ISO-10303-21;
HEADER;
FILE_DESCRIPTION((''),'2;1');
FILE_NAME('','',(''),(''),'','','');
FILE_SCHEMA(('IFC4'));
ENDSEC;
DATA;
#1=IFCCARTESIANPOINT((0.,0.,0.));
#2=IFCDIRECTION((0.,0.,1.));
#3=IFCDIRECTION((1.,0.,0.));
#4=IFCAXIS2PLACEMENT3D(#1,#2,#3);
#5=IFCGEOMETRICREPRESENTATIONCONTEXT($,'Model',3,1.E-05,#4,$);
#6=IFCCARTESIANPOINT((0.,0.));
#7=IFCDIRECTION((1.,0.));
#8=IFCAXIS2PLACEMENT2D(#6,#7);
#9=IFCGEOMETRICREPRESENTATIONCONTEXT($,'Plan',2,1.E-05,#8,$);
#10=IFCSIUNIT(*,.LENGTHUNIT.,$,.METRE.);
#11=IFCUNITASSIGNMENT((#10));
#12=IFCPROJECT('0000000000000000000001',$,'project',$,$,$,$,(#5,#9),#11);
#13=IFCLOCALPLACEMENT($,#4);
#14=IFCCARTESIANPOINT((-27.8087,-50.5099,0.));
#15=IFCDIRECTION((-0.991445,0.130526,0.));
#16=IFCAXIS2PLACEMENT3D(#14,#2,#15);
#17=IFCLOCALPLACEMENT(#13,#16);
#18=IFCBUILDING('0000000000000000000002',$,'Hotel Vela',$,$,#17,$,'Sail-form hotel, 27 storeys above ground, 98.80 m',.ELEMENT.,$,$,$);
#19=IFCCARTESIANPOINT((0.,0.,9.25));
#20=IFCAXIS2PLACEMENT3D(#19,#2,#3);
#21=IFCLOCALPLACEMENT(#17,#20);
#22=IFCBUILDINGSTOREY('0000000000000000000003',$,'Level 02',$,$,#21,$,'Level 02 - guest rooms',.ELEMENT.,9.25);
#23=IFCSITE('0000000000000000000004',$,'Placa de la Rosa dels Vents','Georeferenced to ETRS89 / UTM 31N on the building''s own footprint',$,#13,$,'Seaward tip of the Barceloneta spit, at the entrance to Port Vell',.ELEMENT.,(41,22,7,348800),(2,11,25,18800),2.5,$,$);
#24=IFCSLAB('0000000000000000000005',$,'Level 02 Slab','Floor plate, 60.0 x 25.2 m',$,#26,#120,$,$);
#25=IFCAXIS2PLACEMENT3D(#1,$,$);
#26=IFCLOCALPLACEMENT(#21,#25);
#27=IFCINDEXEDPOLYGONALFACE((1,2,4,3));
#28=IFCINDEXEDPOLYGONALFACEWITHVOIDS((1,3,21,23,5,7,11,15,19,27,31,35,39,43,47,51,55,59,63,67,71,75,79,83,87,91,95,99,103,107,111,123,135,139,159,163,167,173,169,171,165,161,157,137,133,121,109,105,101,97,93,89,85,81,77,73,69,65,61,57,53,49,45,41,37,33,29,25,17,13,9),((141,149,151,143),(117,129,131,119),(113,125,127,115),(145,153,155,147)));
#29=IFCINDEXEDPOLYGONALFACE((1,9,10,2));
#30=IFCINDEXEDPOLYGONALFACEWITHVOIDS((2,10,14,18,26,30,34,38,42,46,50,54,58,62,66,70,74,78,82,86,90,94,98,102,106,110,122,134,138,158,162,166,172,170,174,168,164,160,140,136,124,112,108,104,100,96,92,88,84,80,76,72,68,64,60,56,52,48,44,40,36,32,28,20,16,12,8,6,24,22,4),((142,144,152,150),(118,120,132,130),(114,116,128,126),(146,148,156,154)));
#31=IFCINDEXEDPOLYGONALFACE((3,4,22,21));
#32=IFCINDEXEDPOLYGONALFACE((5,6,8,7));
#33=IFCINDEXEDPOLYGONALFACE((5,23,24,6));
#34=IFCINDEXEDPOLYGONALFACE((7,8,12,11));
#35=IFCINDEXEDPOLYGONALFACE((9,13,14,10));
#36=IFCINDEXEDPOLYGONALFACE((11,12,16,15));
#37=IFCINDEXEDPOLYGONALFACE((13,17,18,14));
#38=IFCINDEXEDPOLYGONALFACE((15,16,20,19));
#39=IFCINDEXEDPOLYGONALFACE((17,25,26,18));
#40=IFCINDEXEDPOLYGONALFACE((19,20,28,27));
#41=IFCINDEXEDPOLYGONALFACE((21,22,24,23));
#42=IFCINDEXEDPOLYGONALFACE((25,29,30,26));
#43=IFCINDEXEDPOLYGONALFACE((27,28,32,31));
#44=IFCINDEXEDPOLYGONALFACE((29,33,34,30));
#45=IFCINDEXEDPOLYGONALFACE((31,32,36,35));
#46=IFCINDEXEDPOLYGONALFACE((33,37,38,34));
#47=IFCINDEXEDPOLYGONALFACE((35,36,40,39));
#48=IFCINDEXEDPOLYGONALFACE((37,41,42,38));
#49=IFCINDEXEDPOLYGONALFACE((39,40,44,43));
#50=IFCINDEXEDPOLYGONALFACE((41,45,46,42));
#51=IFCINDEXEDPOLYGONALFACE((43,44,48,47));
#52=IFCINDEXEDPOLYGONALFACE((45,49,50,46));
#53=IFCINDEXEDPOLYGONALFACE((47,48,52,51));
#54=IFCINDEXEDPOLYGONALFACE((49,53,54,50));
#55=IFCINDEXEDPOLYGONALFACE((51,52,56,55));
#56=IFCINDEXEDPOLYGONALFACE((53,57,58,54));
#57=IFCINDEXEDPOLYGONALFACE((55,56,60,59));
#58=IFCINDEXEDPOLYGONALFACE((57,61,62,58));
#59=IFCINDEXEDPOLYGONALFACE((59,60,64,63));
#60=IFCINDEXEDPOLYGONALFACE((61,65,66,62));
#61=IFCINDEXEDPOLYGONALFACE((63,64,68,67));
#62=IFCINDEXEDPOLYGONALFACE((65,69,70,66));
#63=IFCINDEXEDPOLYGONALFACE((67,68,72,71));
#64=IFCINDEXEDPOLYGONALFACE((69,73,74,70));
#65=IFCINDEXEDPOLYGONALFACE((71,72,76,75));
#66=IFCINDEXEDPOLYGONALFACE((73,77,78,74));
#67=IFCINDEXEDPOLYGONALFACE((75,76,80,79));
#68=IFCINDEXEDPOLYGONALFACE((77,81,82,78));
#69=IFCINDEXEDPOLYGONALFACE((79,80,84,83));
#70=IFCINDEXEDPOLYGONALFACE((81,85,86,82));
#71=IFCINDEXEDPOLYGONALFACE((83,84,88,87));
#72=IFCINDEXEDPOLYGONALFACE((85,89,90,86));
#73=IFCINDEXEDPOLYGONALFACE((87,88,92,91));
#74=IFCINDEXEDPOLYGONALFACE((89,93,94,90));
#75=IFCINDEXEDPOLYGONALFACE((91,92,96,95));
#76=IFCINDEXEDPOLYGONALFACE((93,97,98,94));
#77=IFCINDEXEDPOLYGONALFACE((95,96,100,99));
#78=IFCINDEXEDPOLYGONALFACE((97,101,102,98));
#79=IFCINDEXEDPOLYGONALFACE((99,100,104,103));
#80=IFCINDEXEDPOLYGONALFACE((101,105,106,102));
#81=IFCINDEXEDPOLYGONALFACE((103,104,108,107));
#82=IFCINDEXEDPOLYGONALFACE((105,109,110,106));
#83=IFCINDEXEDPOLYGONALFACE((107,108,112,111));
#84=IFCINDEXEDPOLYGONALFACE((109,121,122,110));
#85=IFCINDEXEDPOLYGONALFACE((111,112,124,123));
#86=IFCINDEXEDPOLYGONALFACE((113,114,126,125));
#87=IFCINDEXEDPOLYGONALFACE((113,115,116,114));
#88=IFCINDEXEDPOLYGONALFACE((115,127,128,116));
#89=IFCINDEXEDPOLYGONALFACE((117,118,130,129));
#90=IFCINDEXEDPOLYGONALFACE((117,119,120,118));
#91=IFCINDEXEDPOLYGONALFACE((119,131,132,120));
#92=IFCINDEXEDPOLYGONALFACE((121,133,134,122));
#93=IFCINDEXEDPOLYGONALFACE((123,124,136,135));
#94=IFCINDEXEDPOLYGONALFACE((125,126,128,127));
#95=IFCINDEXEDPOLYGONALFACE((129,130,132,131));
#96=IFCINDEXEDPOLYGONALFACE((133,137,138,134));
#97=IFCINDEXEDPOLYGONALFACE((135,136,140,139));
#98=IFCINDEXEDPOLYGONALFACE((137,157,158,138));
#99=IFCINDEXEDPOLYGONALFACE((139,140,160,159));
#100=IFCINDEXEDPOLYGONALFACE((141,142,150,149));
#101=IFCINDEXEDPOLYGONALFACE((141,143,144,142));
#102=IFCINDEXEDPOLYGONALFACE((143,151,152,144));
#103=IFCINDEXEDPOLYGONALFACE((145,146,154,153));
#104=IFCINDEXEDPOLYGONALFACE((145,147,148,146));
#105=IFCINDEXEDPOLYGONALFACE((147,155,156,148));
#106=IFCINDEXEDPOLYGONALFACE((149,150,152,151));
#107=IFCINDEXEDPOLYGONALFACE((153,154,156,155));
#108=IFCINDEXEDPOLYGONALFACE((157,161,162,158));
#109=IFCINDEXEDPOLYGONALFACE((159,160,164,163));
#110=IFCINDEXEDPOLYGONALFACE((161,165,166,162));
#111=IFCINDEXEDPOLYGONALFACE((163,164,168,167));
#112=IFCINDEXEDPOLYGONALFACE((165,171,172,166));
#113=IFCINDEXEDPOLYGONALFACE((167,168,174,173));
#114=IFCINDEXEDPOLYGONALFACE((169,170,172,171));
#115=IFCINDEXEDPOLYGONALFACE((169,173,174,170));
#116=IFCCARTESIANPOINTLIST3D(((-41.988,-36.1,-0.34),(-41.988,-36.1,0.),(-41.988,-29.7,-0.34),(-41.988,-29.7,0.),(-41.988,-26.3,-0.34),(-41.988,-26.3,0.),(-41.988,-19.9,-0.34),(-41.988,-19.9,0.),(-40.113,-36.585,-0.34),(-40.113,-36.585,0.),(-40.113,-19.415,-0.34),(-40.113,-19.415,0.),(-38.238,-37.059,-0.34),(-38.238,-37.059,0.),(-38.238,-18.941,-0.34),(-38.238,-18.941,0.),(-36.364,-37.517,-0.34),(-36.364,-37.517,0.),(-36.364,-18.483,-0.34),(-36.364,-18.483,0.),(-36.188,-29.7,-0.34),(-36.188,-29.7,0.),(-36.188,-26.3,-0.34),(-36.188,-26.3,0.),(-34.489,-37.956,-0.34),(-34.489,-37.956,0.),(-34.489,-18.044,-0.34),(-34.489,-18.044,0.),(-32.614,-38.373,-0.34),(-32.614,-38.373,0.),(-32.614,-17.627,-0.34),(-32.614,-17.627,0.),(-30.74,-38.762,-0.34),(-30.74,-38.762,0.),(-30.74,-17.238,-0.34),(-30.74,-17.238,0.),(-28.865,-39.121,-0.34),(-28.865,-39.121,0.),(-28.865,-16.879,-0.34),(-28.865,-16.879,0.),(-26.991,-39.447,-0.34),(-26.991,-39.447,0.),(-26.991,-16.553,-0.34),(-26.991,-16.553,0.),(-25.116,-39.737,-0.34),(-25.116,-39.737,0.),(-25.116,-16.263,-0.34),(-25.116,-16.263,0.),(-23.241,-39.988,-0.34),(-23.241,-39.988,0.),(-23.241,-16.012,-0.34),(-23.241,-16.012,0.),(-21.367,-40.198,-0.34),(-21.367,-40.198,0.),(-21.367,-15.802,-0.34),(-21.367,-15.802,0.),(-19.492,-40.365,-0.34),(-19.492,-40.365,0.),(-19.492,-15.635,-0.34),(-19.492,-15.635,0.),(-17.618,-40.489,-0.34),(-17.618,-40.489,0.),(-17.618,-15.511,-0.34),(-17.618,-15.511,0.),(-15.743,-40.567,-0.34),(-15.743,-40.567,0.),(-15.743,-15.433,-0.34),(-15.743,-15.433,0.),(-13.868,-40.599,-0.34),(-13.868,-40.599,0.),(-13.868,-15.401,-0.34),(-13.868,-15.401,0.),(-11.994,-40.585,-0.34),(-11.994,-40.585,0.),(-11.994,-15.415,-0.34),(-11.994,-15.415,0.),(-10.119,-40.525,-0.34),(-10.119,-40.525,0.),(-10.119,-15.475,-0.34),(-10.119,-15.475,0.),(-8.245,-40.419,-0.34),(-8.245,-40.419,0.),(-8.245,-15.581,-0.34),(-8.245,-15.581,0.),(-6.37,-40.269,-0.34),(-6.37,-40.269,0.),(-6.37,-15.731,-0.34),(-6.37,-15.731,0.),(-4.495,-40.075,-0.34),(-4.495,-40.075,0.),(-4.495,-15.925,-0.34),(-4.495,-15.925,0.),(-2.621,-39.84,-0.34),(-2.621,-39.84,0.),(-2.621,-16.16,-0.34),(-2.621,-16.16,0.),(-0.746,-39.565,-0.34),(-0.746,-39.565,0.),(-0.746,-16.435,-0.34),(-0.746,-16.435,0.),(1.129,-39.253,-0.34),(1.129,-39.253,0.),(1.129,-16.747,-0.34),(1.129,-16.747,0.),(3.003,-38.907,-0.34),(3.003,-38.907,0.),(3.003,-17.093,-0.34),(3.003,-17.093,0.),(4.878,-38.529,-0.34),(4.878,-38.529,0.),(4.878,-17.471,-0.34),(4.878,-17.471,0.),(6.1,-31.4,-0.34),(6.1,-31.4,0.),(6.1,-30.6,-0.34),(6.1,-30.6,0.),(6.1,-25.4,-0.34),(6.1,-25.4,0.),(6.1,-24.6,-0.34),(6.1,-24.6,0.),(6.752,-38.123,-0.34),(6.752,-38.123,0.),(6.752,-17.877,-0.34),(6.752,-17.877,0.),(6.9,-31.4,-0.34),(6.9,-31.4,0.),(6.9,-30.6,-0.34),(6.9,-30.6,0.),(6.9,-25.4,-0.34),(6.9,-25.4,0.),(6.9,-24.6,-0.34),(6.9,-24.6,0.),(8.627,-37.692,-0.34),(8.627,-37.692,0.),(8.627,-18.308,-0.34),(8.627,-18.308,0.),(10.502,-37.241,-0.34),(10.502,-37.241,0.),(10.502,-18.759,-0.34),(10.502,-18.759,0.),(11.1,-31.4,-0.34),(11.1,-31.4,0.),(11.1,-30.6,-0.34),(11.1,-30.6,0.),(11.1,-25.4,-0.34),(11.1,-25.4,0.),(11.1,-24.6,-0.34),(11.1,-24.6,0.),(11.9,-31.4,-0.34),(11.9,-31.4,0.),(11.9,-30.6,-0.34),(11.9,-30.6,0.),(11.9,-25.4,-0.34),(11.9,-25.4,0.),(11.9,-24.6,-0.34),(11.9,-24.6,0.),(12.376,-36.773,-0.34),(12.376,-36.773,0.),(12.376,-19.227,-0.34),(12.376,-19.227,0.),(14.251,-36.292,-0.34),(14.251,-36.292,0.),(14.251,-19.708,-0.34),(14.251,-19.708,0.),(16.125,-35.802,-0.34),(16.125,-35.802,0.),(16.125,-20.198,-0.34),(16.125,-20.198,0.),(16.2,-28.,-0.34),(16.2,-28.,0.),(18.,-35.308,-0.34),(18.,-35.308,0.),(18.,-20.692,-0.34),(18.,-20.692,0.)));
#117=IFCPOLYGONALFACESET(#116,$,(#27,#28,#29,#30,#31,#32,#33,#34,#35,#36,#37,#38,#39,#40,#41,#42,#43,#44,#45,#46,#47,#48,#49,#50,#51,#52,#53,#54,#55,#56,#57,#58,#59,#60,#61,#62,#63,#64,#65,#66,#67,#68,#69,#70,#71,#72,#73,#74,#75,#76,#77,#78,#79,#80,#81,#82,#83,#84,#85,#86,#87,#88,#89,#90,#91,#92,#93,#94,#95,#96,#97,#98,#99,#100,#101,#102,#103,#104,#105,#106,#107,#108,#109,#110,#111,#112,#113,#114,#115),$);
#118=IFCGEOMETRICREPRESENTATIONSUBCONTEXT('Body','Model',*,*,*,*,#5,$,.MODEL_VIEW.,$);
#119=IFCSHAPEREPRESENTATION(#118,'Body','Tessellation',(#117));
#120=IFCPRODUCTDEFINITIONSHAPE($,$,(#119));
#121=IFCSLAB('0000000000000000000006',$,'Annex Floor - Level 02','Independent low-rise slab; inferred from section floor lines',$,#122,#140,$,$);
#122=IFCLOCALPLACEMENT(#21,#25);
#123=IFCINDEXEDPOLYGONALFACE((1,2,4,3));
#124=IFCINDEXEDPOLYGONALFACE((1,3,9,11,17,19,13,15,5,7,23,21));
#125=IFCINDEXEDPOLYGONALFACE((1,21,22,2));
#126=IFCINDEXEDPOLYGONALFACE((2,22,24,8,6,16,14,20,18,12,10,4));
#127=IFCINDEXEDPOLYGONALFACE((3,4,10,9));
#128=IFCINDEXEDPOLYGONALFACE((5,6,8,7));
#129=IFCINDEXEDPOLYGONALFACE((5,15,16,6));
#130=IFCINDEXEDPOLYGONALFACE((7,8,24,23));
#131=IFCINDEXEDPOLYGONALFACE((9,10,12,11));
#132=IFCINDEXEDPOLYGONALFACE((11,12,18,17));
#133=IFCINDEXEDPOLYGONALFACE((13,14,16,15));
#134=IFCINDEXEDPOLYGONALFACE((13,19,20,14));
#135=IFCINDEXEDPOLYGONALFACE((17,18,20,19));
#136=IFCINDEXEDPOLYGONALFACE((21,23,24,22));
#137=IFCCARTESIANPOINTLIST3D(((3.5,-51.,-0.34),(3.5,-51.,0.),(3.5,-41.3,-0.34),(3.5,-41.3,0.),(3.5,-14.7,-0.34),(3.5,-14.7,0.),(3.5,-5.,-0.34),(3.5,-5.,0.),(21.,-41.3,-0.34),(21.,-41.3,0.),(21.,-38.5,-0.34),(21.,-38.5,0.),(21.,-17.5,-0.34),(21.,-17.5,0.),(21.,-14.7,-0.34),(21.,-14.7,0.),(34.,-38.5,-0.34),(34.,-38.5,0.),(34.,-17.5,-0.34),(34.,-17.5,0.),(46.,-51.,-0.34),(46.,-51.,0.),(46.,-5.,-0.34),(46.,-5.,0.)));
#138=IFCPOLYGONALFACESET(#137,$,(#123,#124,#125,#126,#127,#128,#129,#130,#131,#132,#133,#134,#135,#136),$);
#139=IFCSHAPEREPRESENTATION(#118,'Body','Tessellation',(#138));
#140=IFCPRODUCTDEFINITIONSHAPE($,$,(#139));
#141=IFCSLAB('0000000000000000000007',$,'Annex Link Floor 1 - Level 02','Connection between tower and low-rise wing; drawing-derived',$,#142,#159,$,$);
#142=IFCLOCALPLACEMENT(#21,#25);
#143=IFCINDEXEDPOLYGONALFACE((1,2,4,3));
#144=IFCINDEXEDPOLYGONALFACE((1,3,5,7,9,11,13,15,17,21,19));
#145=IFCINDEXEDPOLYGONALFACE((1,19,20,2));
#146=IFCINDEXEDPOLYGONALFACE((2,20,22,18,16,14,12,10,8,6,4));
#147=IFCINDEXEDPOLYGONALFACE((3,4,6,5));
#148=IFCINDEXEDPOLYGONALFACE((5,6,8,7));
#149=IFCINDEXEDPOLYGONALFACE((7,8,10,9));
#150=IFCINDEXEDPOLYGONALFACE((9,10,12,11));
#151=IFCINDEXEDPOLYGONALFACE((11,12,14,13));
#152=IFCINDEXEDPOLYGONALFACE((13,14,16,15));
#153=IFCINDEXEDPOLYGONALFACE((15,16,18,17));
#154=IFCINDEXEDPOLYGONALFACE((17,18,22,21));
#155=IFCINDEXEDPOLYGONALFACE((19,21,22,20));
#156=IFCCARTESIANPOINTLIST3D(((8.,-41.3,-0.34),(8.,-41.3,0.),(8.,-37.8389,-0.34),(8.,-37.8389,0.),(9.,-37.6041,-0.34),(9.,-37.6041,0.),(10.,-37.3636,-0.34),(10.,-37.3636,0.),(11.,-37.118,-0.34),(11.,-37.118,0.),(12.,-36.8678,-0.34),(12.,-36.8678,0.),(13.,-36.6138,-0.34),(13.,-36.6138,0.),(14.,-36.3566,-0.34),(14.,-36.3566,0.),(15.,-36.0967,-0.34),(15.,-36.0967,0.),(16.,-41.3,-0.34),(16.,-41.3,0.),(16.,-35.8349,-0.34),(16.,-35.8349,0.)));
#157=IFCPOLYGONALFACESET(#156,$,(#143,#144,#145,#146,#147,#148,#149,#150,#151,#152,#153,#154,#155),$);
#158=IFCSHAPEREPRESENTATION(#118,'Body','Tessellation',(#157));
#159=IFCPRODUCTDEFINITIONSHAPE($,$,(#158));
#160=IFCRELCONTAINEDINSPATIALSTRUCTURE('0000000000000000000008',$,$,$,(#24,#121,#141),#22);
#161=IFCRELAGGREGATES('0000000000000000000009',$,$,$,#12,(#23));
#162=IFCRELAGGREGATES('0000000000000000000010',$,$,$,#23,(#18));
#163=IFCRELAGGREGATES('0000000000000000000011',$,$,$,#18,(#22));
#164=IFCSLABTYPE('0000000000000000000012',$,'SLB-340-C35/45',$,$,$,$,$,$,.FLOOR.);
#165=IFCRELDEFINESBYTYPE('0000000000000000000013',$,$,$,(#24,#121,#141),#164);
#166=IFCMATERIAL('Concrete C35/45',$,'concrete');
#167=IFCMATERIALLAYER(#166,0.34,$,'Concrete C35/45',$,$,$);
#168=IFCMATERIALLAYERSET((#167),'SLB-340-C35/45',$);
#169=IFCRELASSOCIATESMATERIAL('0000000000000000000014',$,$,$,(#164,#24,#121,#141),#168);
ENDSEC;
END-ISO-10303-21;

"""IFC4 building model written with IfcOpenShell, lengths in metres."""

from ifc_helpers import new_model, si_unit, frame, origin_with_axes, origin_2d_with_axis, place, context, subcontext, project, spatial, line, indexed_curve, outline, extrude, material, layer, layer_set, layer_usage, type_object, element, save


model = new_model("IFC4")

# Units and contexts
model_context = context("Model", 3, precision=1e-05, world=origin_with_axes())
plan_context = context("Plan", 2, precision=1e-05, world=origin_2d_with_axis())
body_context = subcontext(model_context, "Body", "Model", "MODEL_VIEW")
ifc_project = project(units=[si_unit("LENGTHUNIT", "METRE")], contexts=[model_context, plan_context])

# Site, building, storey
site_placement = place(None, origin_with_axes())
site = spatial("IfcSite", under=ifc_project, at=site_placement, Name="Placa de la Rosa dels Vents", Description="Georeferenced to ETRS89 / UTM 31N on the building's own footprint", LongName="Seaward tip of the Barceloneta spit, at the entrance to Port Vell", CompositionType="ELEMENT", RefLatitude=(41, 22, 7, 348800), RefLongitude=(2, 11, 25, 18800), RefElevation=2.5)
building_placement = place(site_placement, frame((-27.8087, -50.5099, 0.0), z_axis=(0.0, 0.0, 1.0), x_axis=(-0.991445, 0.130526, 0.0)))
building = spatial("IfcBuilding", under=site, at=building_placement, Name="Hotel Vela", LongName="Sail-form hotel, 27 storeys above ground, 98.80 m", CompositionType="ELEMENT")
storey_placement = place(building_placement, frame((0.0, 0.0, 9.25), z_axis=(0.0, 0.0, 1.0), x_axis=(1.0, 0.0, 0.0)))
storey = spatial("IfcBuildingStorey", under=building, at=storey_placement, Name="Level 02", LongName="Level 02 - guest rooms", CompositionType="ELEMENT", Elevation=9.25)

# Shared definitions
ifc_material = material(Name="Concrete C35/45", Category="concrete")

# Slab, openings
ifc_layer_1 = layer(ifc_material, 0.34, Name="Concrete C35/45")
ifc_layer_set_1 = layer_set([ifc_layer_1], Name="SLB-340-C35/45")
ifc_layer_usage_1 = layer_usage(ifc_layer_set_1, "AXIS3", "POSITIVE", 0.0)
slab_type = type_object("IfcSlabType", Name="SLB-340-C35/45", PredefinedType="FLOOR", material=ifc_layer_set_1)
slab_1_placement = place(storey_placement, frame((0.0, 0.0, -0.34), z_axis=(0.0, 0.0, 1.0), x_axis=(1.0, 0.0, 0.0)))
slab_1 = element("IfcSlab", 1, at=slab_1_placement, inside=storey, type_object=slab_type, material=ifc_layer_usage_1, Name="Level 02 Slab", Description="Floor plate, 60.0 x 25.2 m", context=body_context, shape_type="SweptSolid", body=[
    extrude(outline(indexed_curve([(-41.988, -36.1), (-40.113, -36.585), (-38.238, -37.059), (-36.364, -37.517), (-34.489, -37.956), (-32.614, -38.373), (-30.74, -38.762), (-28.865, -39.121), (-26.991, -39.447), (-25.116, -39.737), (-23.241, -39.988), (-21.367, -40.198), (-19.492, -40.365), (-17.618, -40.489), (-15.743, -40.567), (-13.868, -40.599), (-11.994, -40.585), (-10.119, -40.525), (-8.245, -40.419), (-6.37, -40.269), (-4.495, -40.075), (-2.621, -39.84), (-0.746, -39.565), (1.129, -39.253), (3.003, -38.907), (4.878, -38.529), (6.752, -38.123), (8.627, -37.692), (10.502, -37.241), (12.376, -36.773), (14.251, -36.292), (16.125, -35.802), (18.0, -35.308), (16.2, -28.0), (18.0, -20.692), (16.125, -20.198), (14.251, -19.708), (12.376, -19.227), (10.502, -18.759), (8.627, -18.308), (6.752, -17.877), (4.878, -17.471), (3.003, -17.093), (1.129, -16.747), (-0.746, -16.435), (-2.621, -16.16), (-4.495, -15.925), (-6.37, -15.731), (-8.245, -15.581), (-10.119, -15.475), (-11.994, -15.415), (-13.868, -15.401), (-15.743, -15.433), (-17.618, -15.511), (-19.492, -15.635), (-21.367, -15.802), (-23.241, -16.012), (-25.116, -16.263), (-26.991, -16.553), (-28.865, -16.879), (-30.74, -17.238), (-32.614, -17.627), (-34.489, -18.044), (-36.364, -18.483), (-38.238, -18.941), (-40.113, -19.415), (-41.988, -19.9), (-41.988, -26.3), (-36.188, -26.3), (-36.188, -29.7), (-41.988, -29.7)], segments=[line(1, 2, 3, 4, 5, 6, 7, 8, 9, 10, 11, 12, 13, 14, 15, 16, 17, 18, 19, 20, 21, 22, 23, 24, 25, 26, 27, 28, 29, 30, 31, 32, 33, 34, 35, 36, 37, 38, 39, 40, 41, 42, 43, 44, 45, 46, 47, 48, 49, 50, 51, 52, 53, 54, 55, 56, 57, 58, 59, 60, 61, 62, 63, 64, 65, 66, 67, 68, 69, 70, 71, 1)])), origin_with_axes(), (0.0, 0.0, 1.0), 0.34),
])
opening_1_placement = place(slab_1_placement, frame((6.1, -31.4, -0.05), z_axis=(0.0, 0.0, 1.0), x_axis=(1.0, 0.0, 0.0)))
element("IfcOpeningElement", 2, at=opening_1_placement, cuts=slab_1, PredefinedType="OPENING", context=body_context, shape_type="SweptSolid", body=[
    extrude(outline(indexed_curve([(0.0, 0.0), (0.8, 0.0), (0.8, 0.8), (0.0, 0.8)], segments=[line(1, 2, 3, 4, 1)])), origin_with_axes(), (0.0, 0.0, 1.0), 0.44),
])
opening_2_placement = place(slab_1_placement, frame((6.1, -25.4, -0.05), z_axis=(0.0, 0.0, 1.0), x_axis=(1.0, 0.0, 0.0)))
element("IfcOpeningElement", 3, at=opening_2_placement, cuts=slab_1, PredefinedType="OPENING", context=body_context, shape_type="SweptSolid", body=[
    extrude(outline(indexed_curve([(0.0, 0.0), (0.8, 0.0), (0.8, 0.8), (0.0, 0.8)], segments=[line(1, 2, 3, 4, 1)])), origin_with_axes(), (0.0, 0.0, 1.0), 0.44),
])
opening_3_placement = place(slab_1_placement, frame((11.1, -31.4, -0.05), z_axis=(0.0, 0.0, 1.0), x_axis=(1.0, 0.0, 0.0)))
element("IfcOpeningElement", 4, at=opening_3_placement, cuts=slab_1, PredefinedType="OPENING", context=body_context, shape_type="SweptSolid", body=[
    extrude(outline(indexed_curve([(0.0, 0.0), (0.8, 0.0), (0.8, 0.8), (0.0, 0.8)], segments=[line(1, 2, 3, 4, 1)])), origin_with_axes(), (0.0, 0.0, 1.0), 0.44),
])
opening_4_placement = place(slab_1_placement, frame((11.1, -25.4, -0.05), z_axis=(0.0, 0.0, 1.0), x_axis=(1.0, 0.0, 0.0)))
element("IfcOpeningElement", 5, at=opening_4_placement, cuts=slab_1, PredefinedType="OPENING", context=body_context, shape_type="SweptSolid", body=[
    extrude(outline(indexed_curve([(0.0, 0.0), (0.8, 0.0), (0.8, 0.8), (0.0, 0.8)], segments=[line(1, 2, 3, 4, 1)])), origin_with_axes(), (0.0, 0.0, 1.0), 0.44),
])

# Slabs
ifc_layer_usage_2 = layer_usage(ifc_layer_set_1, "AXIS3", "POSITIVE", 0.0)
slab_2_placement = place(storey_placement, frame((0.0, 0.0, -0.34), z_axis=(0.0, 0.0, 1.0), x_axis=(1.0, 0.0, 0.0)))
element("IfcSlab", 6, at=slab_2_placement, inside=storey, type_object=slab_type, material=ifc_layer_usage_2, Name="Annex Floor - Level 02", Description="Independent low-rise slab; inferred from section floor lines", context=body_context, shape_type="SweptSolid", body=[
    extrude(outline(indexed_curve([(3.5, -51.0), (46.0, -51.0), (46.0, -5.0), (3.5, -5.0), (3.5, -14.7), (21.0, -14.7), (21.0, -17.5), (34.0, -17.5), (34.0, -38.5), (21.0, -38.5), (21.0, -41.3), (3.5, -41.3)], segments=[line(1, 2, 3, 4, 5, 6, 7, 8, 9, 10, 11, 12, 1)])), origin_with_axes(), (0.0, 0.0, 1.0), 0.34),
])
ifc_layer_usage_3 = layer_usage(ifc_layer_set_1, "AXIS3", "POSITIVE", 0.0)
slab_3_placement = place(storey_placement, frame((0.0, 0.0, -0.34), z_axis=(0.0, 0.0, 1.0), x_axis=(1.0, 0.0, 0.0)))
element("IfcSlab", 7, at=slab_3_placement, inside=storey, type_object=slab_type, material=ifc_layer_usage_3, Name="Annex Link Floor 1 - Level 02", Description="Connection between tower and low-rise wing; drawing-derived", context=body_context, shape_type="SweptSolid", body=[
    extrude(outline(indexed_curve([(8.0, -41.3), (16.0, -41.3), (16.0, -35.8349), (15.0, -36.0967), (14.0, -36.3566), (13.0, -36.6138), (12.0, -36.8678), (11.0, -37.118), (10.0, -37.3636), (9.0, -37.6041), (8.0, -37.8389)], segments=[line(1, 2, 3, 4, 5, 6, 7, 8, 9, 10, 11, 1)])), origin_with_axes(), (0.0, 0.0, 1.0), 0.34),
])

save(model, "model.ifc")
